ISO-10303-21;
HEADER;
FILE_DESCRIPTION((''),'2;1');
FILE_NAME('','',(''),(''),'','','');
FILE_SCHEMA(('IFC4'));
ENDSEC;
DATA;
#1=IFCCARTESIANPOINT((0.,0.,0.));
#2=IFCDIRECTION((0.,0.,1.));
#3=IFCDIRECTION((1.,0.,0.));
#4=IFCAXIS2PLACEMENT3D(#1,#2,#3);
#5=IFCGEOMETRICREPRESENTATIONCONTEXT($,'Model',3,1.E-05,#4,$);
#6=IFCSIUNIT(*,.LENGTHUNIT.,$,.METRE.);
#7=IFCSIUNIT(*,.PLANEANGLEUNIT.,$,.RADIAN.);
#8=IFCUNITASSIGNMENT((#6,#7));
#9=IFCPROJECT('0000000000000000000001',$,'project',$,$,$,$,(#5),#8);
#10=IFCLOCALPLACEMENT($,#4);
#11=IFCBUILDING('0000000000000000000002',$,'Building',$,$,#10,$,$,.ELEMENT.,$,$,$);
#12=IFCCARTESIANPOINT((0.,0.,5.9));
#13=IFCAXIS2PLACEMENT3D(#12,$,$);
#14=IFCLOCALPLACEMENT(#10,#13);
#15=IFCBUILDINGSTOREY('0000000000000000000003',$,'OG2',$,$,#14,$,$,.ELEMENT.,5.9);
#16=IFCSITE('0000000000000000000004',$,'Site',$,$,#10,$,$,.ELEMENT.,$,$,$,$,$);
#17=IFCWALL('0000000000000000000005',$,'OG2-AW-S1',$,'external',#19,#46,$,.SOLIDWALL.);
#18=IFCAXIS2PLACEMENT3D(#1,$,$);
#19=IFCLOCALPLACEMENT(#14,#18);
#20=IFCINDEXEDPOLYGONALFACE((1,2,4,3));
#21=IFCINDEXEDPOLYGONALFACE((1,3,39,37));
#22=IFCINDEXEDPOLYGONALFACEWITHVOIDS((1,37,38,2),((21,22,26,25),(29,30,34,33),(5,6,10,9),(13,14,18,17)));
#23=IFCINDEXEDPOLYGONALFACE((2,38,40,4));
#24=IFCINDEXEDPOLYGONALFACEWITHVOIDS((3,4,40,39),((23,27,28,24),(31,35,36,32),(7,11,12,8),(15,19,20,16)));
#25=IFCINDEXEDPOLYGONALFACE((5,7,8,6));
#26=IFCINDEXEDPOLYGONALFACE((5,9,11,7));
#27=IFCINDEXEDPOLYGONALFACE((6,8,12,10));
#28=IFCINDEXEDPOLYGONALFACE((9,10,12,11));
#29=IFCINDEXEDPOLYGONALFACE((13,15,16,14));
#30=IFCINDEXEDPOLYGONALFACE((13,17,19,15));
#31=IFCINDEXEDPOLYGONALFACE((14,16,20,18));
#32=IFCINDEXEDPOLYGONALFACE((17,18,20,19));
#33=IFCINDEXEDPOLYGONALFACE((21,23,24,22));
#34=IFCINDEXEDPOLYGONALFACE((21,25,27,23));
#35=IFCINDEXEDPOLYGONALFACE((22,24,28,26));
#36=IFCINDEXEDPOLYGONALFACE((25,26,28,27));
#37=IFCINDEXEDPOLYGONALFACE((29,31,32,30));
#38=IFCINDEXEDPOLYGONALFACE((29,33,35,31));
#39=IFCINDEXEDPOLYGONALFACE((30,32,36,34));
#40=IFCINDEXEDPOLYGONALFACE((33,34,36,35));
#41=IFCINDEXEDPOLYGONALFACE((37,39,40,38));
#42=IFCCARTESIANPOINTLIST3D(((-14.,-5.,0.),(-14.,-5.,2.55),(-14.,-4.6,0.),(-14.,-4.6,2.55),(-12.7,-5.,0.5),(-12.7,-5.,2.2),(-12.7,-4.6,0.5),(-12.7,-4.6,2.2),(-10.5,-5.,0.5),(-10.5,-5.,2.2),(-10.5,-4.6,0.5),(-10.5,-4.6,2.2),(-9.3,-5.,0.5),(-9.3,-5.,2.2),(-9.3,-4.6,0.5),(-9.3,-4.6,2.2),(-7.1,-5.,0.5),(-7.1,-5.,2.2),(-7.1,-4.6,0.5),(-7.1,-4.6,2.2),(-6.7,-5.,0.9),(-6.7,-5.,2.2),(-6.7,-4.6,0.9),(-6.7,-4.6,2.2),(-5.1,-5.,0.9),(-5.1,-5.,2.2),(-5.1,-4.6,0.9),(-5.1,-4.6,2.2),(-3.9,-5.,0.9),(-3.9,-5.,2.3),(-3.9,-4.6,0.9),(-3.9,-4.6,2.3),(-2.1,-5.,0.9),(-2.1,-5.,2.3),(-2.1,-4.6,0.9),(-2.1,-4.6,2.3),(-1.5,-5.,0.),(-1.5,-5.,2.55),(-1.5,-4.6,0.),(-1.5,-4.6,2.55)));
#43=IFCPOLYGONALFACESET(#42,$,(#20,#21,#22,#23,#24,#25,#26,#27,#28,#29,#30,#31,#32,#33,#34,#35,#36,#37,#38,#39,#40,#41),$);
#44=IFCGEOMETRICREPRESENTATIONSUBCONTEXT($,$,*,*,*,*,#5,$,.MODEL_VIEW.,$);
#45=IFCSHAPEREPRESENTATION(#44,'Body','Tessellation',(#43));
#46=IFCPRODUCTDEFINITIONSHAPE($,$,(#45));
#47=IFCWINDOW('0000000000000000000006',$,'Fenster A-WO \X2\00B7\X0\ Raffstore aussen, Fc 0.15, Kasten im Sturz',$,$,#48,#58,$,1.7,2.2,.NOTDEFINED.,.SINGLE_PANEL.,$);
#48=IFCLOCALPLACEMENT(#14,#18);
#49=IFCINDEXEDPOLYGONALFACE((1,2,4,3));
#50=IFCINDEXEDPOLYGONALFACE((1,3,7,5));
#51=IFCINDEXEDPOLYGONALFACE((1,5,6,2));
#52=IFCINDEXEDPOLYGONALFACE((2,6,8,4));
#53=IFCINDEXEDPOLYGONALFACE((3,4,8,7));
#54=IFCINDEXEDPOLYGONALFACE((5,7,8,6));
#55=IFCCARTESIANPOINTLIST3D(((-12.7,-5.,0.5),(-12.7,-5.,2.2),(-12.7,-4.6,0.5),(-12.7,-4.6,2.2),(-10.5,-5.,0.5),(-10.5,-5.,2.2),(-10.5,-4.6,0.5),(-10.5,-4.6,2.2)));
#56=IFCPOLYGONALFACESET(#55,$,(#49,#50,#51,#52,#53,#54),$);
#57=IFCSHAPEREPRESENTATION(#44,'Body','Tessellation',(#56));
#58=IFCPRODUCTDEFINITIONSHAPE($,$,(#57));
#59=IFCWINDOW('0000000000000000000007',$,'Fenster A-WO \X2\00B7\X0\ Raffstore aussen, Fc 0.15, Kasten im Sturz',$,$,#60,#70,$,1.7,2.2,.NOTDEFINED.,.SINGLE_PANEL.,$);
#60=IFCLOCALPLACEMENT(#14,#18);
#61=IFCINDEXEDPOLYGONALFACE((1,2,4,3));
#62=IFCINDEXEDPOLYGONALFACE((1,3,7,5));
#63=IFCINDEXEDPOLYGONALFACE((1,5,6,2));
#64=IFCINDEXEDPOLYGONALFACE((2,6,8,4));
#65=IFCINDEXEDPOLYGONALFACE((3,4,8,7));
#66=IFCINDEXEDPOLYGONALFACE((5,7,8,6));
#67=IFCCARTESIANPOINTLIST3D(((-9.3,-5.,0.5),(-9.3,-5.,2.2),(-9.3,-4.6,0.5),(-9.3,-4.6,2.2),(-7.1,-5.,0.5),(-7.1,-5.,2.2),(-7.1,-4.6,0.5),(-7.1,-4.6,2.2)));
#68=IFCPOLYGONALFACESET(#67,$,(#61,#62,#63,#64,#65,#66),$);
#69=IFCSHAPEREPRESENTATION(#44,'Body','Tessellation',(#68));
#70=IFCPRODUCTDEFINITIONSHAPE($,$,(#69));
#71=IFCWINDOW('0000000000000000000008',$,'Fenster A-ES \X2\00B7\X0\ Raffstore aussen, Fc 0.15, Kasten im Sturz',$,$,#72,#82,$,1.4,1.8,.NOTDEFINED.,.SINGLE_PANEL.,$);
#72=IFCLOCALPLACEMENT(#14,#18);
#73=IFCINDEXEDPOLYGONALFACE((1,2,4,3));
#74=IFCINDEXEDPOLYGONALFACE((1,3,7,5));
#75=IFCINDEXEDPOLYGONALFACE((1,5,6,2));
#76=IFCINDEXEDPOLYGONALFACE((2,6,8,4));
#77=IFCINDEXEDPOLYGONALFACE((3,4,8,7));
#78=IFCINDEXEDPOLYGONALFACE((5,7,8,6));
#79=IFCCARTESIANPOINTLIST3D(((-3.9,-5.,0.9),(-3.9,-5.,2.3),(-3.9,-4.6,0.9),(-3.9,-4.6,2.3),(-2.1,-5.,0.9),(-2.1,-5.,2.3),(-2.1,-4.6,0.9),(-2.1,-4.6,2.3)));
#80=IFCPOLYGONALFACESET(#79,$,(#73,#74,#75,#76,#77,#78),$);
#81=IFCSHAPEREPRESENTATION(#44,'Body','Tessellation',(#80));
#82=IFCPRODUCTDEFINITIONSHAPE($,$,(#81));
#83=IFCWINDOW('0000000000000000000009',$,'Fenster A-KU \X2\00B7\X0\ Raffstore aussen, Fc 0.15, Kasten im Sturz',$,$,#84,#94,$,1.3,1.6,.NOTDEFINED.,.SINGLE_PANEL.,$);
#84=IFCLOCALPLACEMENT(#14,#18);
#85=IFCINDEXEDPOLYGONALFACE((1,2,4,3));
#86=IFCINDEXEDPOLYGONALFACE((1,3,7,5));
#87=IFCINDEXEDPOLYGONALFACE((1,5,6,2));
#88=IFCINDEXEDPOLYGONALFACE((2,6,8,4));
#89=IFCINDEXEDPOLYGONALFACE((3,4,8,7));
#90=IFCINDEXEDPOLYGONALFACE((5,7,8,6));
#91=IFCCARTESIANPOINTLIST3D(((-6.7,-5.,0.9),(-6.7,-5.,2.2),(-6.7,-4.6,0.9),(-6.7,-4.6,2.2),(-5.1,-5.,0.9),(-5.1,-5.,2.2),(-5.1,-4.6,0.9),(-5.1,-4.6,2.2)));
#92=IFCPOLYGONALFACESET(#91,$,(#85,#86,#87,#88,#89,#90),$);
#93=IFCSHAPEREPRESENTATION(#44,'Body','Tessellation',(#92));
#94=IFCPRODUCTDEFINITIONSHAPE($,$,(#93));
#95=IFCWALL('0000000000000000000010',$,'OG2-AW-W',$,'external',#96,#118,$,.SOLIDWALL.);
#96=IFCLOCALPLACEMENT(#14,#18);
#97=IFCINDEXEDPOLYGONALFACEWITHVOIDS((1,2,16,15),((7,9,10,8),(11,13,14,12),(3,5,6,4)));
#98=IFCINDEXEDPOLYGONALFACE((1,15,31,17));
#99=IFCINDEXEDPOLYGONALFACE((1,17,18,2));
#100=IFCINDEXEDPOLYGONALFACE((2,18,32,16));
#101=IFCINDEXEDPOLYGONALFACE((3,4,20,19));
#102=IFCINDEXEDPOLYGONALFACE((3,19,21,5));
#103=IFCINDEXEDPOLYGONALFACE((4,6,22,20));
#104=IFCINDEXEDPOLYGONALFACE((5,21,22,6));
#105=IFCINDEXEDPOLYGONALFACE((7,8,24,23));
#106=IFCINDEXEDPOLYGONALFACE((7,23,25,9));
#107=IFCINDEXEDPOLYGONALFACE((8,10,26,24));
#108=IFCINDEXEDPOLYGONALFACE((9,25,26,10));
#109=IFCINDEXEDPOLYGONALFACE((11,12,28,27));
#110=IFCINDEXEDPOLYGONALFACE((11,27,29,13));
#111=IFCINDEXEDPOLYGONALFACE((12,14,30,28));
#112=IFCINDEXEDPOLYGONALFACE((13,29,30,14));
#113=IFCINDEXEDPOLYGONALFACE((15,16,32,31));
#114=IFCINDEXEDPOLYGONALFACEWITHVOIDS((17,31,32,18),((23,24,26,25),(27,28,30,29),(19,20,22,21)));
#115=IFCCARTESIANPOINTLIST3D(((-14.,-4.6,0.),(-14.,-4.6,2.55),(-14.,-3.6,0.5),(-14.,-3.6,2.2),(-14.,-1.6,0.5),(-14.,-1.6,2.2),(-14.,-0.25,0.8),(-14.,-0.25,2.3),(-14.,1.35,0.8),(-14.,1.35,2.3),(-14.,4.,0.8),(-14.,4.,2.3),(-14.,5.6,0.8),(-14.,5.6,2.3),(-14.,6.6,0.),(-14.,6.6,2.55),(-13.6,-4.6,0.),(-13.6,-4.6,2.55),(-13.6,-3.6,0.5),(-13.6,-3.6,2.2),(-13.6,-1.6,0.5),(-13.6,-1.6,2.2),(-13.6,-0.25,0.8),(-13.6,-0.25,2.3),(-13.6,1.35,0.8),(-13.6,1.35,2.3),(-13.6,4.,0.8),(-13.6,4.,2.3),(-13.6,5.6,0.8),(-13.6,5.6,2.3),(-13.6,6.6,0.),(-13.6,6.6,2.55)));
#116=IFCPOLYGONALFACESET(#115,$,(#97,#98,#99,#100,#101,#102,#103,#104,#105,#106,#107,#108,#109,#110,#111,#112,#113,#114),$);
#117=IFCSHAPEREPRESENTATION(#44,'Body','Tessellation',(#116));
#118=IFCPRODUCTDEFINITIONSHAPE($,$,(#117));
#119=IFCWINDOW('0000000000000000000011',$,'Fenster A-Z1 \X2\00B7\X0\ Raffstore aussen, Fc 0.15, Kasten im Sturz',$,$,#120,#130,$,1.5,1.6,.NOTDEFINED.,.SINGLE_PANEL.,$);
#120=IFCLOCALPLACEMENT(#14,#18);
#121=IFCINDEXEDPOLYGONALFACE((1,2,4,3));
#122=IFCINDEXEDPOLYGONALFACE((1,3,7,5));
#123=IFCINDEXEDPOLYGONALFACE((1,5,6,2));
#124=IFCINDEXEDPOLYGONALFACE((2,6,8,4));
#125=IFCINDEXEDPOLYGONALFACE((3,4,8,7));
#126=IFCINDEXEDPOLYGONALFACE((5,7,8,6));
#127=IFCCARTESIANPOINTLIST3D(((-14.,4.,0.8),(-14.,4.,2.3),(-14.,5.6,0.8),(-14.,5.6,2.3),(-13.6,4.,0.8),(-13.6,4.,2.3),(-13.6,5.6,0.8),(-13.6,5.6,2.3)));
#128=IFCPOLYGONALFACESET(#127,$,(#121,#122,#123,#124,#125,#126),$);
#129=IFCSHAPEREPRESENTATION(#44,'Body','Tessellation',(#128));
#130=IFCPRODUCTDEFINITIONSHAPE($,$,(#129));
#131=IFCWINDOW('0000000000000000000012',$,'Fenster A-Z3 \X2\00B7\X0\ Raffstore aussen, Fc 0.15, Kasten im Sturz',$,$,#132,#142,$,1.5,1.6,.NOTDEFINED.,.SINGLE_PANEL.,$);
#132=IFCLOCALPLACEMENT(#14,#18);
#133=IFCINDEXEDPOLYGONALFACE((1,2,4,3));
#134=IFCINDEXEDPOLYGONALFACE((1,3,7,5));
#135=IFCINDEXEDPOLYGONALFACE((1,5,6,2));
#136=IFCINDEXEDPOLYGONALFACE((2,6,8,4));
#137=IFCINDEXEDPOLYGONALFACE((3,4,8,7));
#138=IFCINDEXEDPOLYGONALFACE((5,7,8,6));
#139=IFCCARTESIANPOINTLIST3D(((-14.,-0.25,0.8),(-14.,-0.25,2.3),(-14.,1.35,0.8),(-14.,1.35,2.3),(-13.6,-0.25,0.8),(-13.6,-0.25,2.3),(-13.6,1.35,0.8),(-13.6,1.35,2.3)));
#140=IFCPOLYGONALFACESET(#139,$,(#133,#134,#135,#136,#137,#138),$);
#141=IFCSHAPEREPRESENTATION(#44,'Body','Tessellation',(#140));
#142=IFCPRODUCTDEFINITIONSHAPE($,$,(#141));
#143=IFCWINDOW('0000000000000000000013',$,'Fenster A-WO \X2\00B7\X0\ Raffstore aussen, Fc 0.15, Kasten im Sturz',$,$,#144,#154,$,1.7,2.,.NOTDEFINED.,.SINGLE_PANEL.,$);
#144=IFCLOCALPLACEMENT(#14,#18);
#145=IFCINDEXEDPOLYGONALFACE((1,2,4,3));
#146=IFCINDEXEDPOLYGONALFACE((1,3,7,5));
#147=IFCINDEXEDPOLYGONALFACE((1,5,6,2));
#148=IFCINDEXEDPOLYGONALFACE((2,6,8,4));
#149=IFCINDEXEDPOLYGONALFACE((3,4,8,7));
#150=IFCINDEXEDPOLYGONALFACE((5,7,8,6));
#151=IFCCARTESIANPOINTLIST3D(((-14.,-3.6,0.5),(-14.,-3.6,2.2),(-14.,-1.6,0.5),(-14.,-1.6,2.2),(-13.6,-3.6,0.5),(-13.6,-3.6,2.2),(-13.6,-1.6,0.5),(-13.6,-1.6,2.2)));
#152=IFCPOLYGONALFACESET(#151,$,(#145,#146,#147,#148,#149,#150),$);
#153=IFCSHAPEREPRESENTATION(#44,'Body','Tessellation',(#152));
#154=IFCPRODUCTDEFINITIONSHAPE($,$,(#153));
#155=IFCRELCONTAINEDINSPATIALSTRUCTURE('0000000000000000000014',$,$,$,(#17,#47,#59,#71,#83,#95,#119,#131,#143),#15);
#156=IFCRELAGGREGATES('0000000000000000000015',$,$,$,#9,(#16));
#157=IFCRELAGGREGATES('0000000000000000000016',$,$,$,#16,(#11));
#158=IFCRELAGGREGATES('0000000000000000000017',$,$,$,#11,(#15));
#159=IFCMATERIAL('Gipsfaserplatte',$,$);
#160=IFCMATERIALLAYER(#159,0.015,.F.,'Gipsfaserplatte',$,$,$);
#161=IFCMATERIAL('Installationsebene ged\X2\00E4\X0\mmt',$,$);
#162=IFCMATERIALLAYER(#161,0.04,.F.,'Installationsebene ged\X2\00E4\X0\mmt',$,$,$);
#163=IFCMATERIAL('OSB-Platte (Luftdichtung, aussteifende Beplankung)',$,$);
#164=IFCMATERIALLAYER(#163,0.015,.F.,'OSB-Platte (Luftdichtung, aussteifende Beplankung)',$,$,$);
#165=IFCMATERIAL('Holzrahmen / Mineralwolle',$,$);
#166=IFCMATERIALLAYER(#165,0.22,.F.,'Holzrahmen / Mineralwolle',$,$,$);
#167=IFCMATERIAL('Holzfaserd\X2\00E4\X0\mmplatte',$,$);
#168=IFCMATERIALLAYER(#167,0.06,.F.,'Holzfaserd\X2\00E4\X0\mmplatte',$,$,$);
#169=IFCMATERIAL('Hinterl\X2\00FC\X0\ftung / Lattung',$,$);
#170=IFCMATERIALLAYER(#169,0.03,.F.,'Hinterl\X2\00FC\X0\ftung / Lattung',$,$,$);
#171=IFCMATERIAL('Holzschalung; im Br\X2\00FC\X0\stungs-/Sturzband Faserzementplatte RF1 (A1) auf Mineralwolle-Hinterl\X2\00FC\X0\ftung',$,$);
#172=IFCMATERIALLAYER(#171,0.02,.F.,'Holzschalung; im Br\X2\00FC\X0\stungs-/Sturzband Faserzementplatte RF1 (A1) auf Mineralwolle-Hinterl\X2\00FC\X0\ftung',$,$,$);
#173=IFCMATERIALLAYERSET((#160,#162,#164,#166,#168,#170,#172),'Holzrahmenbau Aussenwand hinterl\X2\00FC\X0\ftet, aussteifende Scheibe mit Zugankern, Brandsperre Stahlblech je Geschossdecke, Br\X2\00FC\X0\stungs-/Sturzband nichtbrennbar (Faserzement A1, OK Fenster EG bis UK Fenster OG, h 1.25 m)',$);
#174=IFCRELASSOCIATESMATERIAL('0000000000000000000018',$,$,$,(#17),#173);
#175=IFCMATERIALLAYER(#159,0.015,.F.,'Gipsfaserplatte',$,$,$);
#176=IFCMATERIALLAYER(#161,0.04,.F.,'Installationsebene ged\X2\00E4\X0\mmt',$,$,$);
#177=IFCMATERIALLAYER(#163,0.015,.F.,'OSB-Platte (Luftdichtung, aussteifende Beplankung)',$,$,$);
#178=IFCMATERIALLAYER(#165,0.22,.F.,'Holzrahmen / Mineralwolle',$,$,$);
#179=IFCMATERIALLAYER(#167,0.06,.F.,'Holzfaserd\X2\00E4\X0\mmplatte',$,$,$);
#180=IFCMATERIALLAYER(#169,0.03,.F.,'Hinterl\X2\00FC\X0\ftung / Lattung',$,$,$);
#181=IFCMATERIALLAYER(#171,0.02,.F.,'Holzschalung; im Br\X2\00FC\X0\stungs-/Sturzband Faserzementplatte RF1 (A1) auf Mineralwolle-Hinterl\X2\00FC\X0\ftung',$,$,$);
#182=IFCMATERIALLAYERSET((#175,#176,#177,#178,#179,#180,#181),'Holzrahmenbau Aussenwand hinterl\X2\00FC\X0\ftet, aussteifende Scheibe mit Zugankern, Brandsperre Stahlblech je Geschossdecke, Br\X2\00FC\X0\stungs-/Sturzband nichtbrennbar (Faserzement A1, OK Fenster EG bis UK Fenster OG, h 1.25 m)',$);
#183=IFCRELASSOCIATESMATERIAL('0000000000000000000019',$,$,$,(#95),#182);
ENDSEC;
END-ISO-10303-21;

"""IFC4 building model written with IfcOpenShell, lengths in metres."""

from ifc_helpers import new_model, si_unit, frame, frame_2d, origin, origin_with_axes, place, context, subcontext, project, spatial, rectangle, extrude, material, layer, layer_set, element, fill, save


model = new_model("IFC4")

# Units and contexts
model_context = context("Model", 3, precision=1e-05, world=origin_with_axes())
sub_context = subcontext(model_context, None, None, "MODEL_VIEW")
ifc_project = project(units=[si_unit("LENGTHUNIT", "METRE"), si_unit("PLANEANGLEUNIT", "RADIAN")], contexts=[model_context])

# Site, building, storey
placement = place(None, origin_with_axes())
site = spatial("IfcSite", under=ifc_project, at=placement, Name="Site", CompositionType="ELEMENT")
building = spatial("IfcBuilding", under=site, at=placement, Name="Building", CompositionType="ELEMENT")
storey_placement = place(placement, frame((0.0, 0.0, 5.9)))
storey = spatial("IfcBuildingStorey", under=building, at=storey_placement, Name="OG2", CompositionType="ELEMENT", Elevation=5.9)

# Walls, openings, windows
ifc_material_1 = material(Name="Gipsfaserplatte")
ifc_layer_1 = layer(ifc_material_1, 0.015, ventilated=False, Name="Gipsfaserplatte")
ifc_material_2 = material(Name="Installationsebene gedämmt")
ifc_layer_2 = layer(ifc_material_2, 0.04, ventilated=False, Name="Installationsebene gedämmt")
ifc_material_3 = material(Name="OSB-Platte (Luftdichtung, aussteifende Beplankung)")
ifc_layer_3 = layer(ifc_material_3, 0.015, ventilated=False, Name="OSB-Platte (Luftdichtung, aussteifende Beplankung)")
ifc_material_4 = material(Name="Holzrahmen / Mineralwolle")
ifc_layer_4 = layer(ifc_material_4, 0.22, ventilated=False, Name="Holzrahmen / Mineralwolle")
ifc_material_5 = material(Name="Holzfaserdämmplatte")
ifc_layer_5 = layer(ifc_material_5, 0.06, ventilated=False, Name="Holzfaserdämmplatte")
ifc_material_6 = material(Name="Hinterlüftung / Lattung")
ifc_layer_6 = layer(ifc_material_6, 0.03, ventilated=False, Name="Hinterlüftung / Lattung")
ifc_material_7 = material(Name="Holzschalung; im Brüstungs-/Sturzband Faserzementplatte RF1 (A1) auf Mineralwolle-Hinterlüftung")
ifc_layer_7 = layer(ifc_material_7, 0.02, ventilated=False, Name="Holzschalung; im Brüstungs-/Sturzband Faserzementplatte RF1 (A1) auf Mineralwolle-Hinterlüftung")
ifc_layer_set_1 = layer_set([ifc_layer_1, ifc_layer_2, ifc_layer_3, ifc_layer_4, ifc_layer_5, ifc_layer_6, ifc_layer_7], Name="Holzrahmenbau Aussenwand hinterlüftet, aussteifende Scheibe mit Zugankern, Brandsperre Stahlblech je Geschossdecke, Brüstungs-/Sturzband nichtbrennbar (Faserzement A1, OK Fenster EG bis UK Fenster OG, h 1.25 m)")
wall_1_placement = place(storey_placement, frame((-14.0, -4.8, 0.0), z_axis=(0.0, 0.0, 1.0), x_axis=(1.0, 0.0, 0.0)))
wall_1 = element("IfcWall", 1, at=wall_1_placement, inside=storey, material=ifc_layer_set_1, Name="OG2-AW-S1", ObjectType="external", PredefinedType="SOLIDWALL", context=sub_context, shape_type="SweptSolid", body=[
    extrude(rectangle(XDim=12.5, YDim=0.4, at=frame_2d((6.25, 0.0))), origin(), (0.0, 0.0, 1.0), 2.55),
])
opening_1_placement = place(wall_1_placement, frame((2.4, 0.25, 0.5), z_axis=(0.0, -1.0, 0.0), x_axis=(1.0, 0.0, 0.0)))
opening_1 = element("IfcOpeningElement", 2, at=opening_1_placement, cuts=wall_1, PredefinedType="OPENING", context=sub_context, shape_type="SweptSolid", body=[
    extrude(rectangle(XDim=2.2, YDim=1.7, at=frame_2d((0.0, 0.85))), origin(), (0.0, 0.0, 1.0), 0.5),
])
opening_2_placement = place(wall_1_placement, frame((5.8, 0.25, 0.5), z_axis=(0.0, -1.0, 0.0), x_axis=(1.0, 0.0, 0.0)))
opening_2 = element("IfcOpeningElement", 3, at=opening_2_placement, cuts=wall_1, PredefinedType="OPENING", context=sub_context, shape_type="SweptSolid", body=[
    extrude(rectangle(XDim=2.2, YDim=1.7, at=frame_2d((0.0, 0.85))), origin(), (0.0, 0.0, 1.0), 0.5),
])
opening_3_placement = place(wall_1_placement, frame((11.0, 0.25, 0.9), z_axis=(0.0, -1.0, 0.0), x_axis=(1.0, 0.0, 0.0)))
opening_3 = element("IfcOpeningElement", 4, at=opening_3_placement, cuts=wall_1, PredefinedType="OPENING", context=sub_context, shape_type="SweptSolid", body=[
    extrude(rectangle(XDim=1.8, YDim=1.4, at=frame_2d((0.0, 0.7))), origin(), (0.0, 0.0, 1.0), 0.5),
])
opening_4_placement = place(wall_1_placement, frame((8.1, 0.25, 0.9), z_axis=(0.0, -1.0, 0.0), x_axis=(1.0, 0.0, 0.0)))
opening_4 = element("IfcOpeningElement", 5, at=opening_4_placement, cuts=wall_1, PredefinedType="OPENING", context=sub_context, shape_type="SweptSolid", body=[
    extrude(rectangle(XDim=1.6, YDim=1.3, at=frame_2d((0.0, 0.65))), origin(), (0.0, 0.0, 1.0), 0.5),
])
window_1_placement = place(wall_1_placement, frame((2.4, 0.2, 0.5), z_axis=(0.0, -1.0, 0.0), x_axis=(1.0, 0.0, 0.0)))
window_1 = element("IfcWindow", 6, at=window_1_placement, inside=storey, Name="Fenster A-WO · Raffstore aussen, Fc 0.15, Kasten im Sturz", OverallHeight=1.7, OverallWidth=2.2, PartitioningType="SINGLE_PANEL", PredefinedType="NOTDEFINED", context=sub_context, shape_type="SweptSolid", body=[
    extrude(rectangle(XDim=2.2, YDim=1.7, at=frame_2d((0.0, 0.85))), origin(), (0.0, 0.0, 1.0), 0.4),
])
fill(opening_1, window_1)
window_2_placement = place(wall_1_placement, frame((5.8, 0.2, 0.5), z_axis=(0.0, -1.0, 0.0), x_axis=(1.0, 0.0, 0.0)))
window_2 = element("IfcWindow", 7, at=window_2_placement, inside=storey, Name="Fenster A-WO · Raffstore aussen, Fc 0.15, Kasten im Sturz", OverallHeight=1.7, OverallWidth=2.2, PartitioningType="SINGLE_PANEL", PredefinedType="NOTDEFINED", context=sub_context, shape_type="SweptSolid", body=[
    extrude(rectangle(XDim=2.2, YDim=1.7, at=frame_2d((0.0, 0.85))), origin(), (0.0, 0.0, 1.0), 0.4),
])
fill(opening_2, window_2)
window_3_placement = place(wall_1_placement, frame((11.0, 0.2, 0.9), z_axis=(0.0, -1.0, 0.0), x_axis=(1.0, 0.0, 0.0)))
window_3 = element("IfcWindow", 8, at=window_3_placement, inside=storey, Name="Fenster A-ES · Raffstore aussen, Fc 0.15, Kasten im Sturz", OverallHeight=1.4, OverallWidth=1.8, PartitioningType="SINGLE_PANEL", PredefinedType="NOTDEFINED", context=sub_context, shape_type="SweptSolid", body=[
    extrude(rectangle(XDim=1.8, YDim=1.4, at=frame_2d((0.0, 0.7))), origin(), (0.0, 0.0, 1.0), 0.4),
])
fill(opening_3, window_3)
window_4_placement = place(wall_1_placement, frame((8.1, 0.2, 0.9), z_axis=(0.0, -1.0, 0.0), x_axis=(1.0, 0.0, 0.0)))
window_4 = element("IfcWindow", 9, at=window_4_placement, inside=storey, Name="Fenster A-KU · Raffstore aussen, Fc 0.15, Kasten im Sturz", OverallHeight=1.3, OverallWidth=1.6, PartitioningType="SINGLE_PANEL", PredefinedType="NOTDEFINED", context=sub_context, shape_type="SweptSolid", body=[
    extrude(rectangle(XDim=1.6, YDim=1.3, at=frame_2d((0.0, 0.65))), origin(), (0.0, 0.0, 1.0), 0.4),
])
fill(opening_4, window_4)
ifc_layer_8 = layer(ifc_material_1, 0.015, ventilated=False, Name="Gipsfaserplatte")
ifc_layer_9 = layer(ifc_material_2, 0.04, ventilated=False, Name="Installationsebene gedämmt")
ifc_layer_10 = layer(ifc_material_3, 0.015, ventilated=False, Name="OSB-Platte (Luftdichtung, aussteifende Beplankung)")
ifc_layer_11 = layer(ifc_material_4, 0.22, ventilated=False, Name="Holzrahmen / Mineralwolle")
ifc_layer_12 = layer(ifc_material_5, 0.06, ventilated=False, Name="Holzfaserdämmplatte")
ifc_layer_13 = layer(ifc_material_6, 0.03, ventilated=False, Name="Hinterlüftung / Lattung")
ifc_layer_14 = layer(ifc_material_7, 0.02, ventilated=False, Name="Holzschalung; im Brüstungs-/Sturzband Faserzementplatte RF1 (A1) auf Mineralwolle-Hinterlüftung")
ifc_layer_set_2 = layer_set([ifc_layer_8, ifc_layer_9, ifc_layer_10, ifc_layer_11, ifc_layer_12, ifc_layer_13, ifc_layer_14], Name="Holzrahmenbau Aussenwand hinterlüftet, aussteifende Scheibe mit Zugankern, Brandsperre Stahlblech je Geschossdecke, Brüstungs-/Sturzband nichtbrennbar (Faserzement A1, OK Fenster EG bis UK Fenster OG, h 1.25 m)")
wall_2_placement = place(storey_placement, frame((-13.8, -4.6, 0.0), z_axis=(0.0, 0.0, 1.0), x_axis=(0.0, 1.0, 0.0)))
wall_2 = element("IfcWall", 10, at=wall_2_placement, inside=storey, material=ifc_layer_set_2, Name="OG2-AW-W", ObjectType="external", PredefinedType="SOLIDWALL", context=sub_context, shape_type="SweptSolid", body=[
    extrude(rectangle(XDim=11.2, YDim=0.4, at=frame_2d((5.6, 0.0))), origin(), (0.0, 0.0, 1.0), 2.55),
])
opening_5_placement = place(wall_2_placement, frame((9.4, 0.25, 0.8), z_axis=(0.0, -1.0, 0.0), x_axis=(1.0, 0.0, 0.0)))
opening_5 = element("IfcOpeningElement", 11, at=opening_5_placement, cuts=wall_2, PredefinedType="OPENING", context=sub_context, shape_type="SweptSolid", body=[
    extrude(rectangle(XDim=1.6, YDim=1.5, at=frame_2d((0.0, 0.75))), origin(), (0.0, 0.0, 1.0), 0.5),
])
opening_6_placement = place(wall_2_placement, frame((5.15, 0.25, 0.8), z_axis=(0.0, -1.0, 0.0), x_axis=(1.0, 0.0, 0.0)))
opening_6 = element("IfcOpeningElement", 12, at=opening_6_placement, cuts=wall_2, PredefinedType="OPENING", context=sub_context, shape_type="SweptSolid", body=[
    extrude(rectangle(XDim=1.6, YDim=1.5, at=frame_2d((0.0, 0.75))), origin(), (0.0, 0.0, 1.0), 0.5),
])
opening_7_placement = place(wall_2_placement, frame((2.0, 0.25, 0.5), z_axis=(0.0, -1.0, 0.0), x_axis=(1.0, 0.0, 0.0)))
opening_7 = element("IfcOpeningElement", 13, at=opening_7_placement, cuts=wall_2, PredefinedType="OPENING", context=sub_context, shape_type="SweptSolid", body=[
    extrude(rectangle(XDim=2.0, YDim=1.7, at=frame_2d((0.0, 0.85))), origin(), (0.0, 0.0, 1.0), 0.5),
])
window_5_placement = place(wall_2_placement, frame((9.4, 0.2, 0.8), z_axis=(0.0, -1.0, 0.0), x_axis=(1.0, 0.0, 0.0)))
window_5 = element("IfcWindow", 14, at=window_5_placement, inside=storey, Name="Fenster A-Z1 · Raffstore aussen, Fc 0.15, Kasten im Sturz", OverallHeight=1.5, OverallWidth=1.6, PartitioningType="SINGLE_PANEL", PredefinedType="NOTDEFINED", context=sub_context, shape_type="SweptSolid", body=[
    extrude(rectangle(XDim=1.6, YDim=1.5, at=frame_2d((0.0, 0.75))), origin(), (0.0, 0.0, 1.0), 0.4),
])
fill(opening_5, window_5)
window_6_placement = place(wall_2_placement, frame((5.15, 0.2, 0.8), z_axis=(0.0, -1.0, 0.0), x_axis=(1.0, 0.0, 0.0)))
window_6 = element("IfcWindow", 15, at=window_6_placement, inside=storey, Name="Fenster A-Z3 · Raffstore aussen, Fc 0.15, Kasten im Sturz", OverallHeight=1.5, OverallWidth=1.6, PartitioningType="SINGLE_PANEL", PredefinedType="NOTDEFINED", context=sub_context, shape_type="SweptSolid", body=[
    extrude(rectangle(XDim=1.6, YDim=1.5, at=frame_2d((0.0, 0.75))), origin(), (0.0, 0.0, 1.0), 0.4),
])
fill(opening_6, window_6)
window_7_placement = place(wall_2_placement, frame((2.0, 0.2, 0.5), z_axis=(0.0, -1.0, 0.0), x_axis=(1.0, 0.0, 0.0)))
window_7 = element("IfcWindow", 16, at=window_7_placement, inside=storey, Name="Fenster A-WO · Raffstore aussen, Fc 0.15, Kasten im Sturz", OverallHeight=1.7, OverallWidth=2.0, PartitioningType="SINGLE_PANEL", PredefinedType="NOTDEFINED", context=sub_context, shape_type="SweptSolid", body=[
    extrude(rectangle(XDim=2.0, YDim=1.7, at=frame_2d((0.0, 0.85))), origin(), (0.0, 0.0, 1.0), 0.4),
])
fill(opening_7, window_7)

save(model, "model.ifc")
